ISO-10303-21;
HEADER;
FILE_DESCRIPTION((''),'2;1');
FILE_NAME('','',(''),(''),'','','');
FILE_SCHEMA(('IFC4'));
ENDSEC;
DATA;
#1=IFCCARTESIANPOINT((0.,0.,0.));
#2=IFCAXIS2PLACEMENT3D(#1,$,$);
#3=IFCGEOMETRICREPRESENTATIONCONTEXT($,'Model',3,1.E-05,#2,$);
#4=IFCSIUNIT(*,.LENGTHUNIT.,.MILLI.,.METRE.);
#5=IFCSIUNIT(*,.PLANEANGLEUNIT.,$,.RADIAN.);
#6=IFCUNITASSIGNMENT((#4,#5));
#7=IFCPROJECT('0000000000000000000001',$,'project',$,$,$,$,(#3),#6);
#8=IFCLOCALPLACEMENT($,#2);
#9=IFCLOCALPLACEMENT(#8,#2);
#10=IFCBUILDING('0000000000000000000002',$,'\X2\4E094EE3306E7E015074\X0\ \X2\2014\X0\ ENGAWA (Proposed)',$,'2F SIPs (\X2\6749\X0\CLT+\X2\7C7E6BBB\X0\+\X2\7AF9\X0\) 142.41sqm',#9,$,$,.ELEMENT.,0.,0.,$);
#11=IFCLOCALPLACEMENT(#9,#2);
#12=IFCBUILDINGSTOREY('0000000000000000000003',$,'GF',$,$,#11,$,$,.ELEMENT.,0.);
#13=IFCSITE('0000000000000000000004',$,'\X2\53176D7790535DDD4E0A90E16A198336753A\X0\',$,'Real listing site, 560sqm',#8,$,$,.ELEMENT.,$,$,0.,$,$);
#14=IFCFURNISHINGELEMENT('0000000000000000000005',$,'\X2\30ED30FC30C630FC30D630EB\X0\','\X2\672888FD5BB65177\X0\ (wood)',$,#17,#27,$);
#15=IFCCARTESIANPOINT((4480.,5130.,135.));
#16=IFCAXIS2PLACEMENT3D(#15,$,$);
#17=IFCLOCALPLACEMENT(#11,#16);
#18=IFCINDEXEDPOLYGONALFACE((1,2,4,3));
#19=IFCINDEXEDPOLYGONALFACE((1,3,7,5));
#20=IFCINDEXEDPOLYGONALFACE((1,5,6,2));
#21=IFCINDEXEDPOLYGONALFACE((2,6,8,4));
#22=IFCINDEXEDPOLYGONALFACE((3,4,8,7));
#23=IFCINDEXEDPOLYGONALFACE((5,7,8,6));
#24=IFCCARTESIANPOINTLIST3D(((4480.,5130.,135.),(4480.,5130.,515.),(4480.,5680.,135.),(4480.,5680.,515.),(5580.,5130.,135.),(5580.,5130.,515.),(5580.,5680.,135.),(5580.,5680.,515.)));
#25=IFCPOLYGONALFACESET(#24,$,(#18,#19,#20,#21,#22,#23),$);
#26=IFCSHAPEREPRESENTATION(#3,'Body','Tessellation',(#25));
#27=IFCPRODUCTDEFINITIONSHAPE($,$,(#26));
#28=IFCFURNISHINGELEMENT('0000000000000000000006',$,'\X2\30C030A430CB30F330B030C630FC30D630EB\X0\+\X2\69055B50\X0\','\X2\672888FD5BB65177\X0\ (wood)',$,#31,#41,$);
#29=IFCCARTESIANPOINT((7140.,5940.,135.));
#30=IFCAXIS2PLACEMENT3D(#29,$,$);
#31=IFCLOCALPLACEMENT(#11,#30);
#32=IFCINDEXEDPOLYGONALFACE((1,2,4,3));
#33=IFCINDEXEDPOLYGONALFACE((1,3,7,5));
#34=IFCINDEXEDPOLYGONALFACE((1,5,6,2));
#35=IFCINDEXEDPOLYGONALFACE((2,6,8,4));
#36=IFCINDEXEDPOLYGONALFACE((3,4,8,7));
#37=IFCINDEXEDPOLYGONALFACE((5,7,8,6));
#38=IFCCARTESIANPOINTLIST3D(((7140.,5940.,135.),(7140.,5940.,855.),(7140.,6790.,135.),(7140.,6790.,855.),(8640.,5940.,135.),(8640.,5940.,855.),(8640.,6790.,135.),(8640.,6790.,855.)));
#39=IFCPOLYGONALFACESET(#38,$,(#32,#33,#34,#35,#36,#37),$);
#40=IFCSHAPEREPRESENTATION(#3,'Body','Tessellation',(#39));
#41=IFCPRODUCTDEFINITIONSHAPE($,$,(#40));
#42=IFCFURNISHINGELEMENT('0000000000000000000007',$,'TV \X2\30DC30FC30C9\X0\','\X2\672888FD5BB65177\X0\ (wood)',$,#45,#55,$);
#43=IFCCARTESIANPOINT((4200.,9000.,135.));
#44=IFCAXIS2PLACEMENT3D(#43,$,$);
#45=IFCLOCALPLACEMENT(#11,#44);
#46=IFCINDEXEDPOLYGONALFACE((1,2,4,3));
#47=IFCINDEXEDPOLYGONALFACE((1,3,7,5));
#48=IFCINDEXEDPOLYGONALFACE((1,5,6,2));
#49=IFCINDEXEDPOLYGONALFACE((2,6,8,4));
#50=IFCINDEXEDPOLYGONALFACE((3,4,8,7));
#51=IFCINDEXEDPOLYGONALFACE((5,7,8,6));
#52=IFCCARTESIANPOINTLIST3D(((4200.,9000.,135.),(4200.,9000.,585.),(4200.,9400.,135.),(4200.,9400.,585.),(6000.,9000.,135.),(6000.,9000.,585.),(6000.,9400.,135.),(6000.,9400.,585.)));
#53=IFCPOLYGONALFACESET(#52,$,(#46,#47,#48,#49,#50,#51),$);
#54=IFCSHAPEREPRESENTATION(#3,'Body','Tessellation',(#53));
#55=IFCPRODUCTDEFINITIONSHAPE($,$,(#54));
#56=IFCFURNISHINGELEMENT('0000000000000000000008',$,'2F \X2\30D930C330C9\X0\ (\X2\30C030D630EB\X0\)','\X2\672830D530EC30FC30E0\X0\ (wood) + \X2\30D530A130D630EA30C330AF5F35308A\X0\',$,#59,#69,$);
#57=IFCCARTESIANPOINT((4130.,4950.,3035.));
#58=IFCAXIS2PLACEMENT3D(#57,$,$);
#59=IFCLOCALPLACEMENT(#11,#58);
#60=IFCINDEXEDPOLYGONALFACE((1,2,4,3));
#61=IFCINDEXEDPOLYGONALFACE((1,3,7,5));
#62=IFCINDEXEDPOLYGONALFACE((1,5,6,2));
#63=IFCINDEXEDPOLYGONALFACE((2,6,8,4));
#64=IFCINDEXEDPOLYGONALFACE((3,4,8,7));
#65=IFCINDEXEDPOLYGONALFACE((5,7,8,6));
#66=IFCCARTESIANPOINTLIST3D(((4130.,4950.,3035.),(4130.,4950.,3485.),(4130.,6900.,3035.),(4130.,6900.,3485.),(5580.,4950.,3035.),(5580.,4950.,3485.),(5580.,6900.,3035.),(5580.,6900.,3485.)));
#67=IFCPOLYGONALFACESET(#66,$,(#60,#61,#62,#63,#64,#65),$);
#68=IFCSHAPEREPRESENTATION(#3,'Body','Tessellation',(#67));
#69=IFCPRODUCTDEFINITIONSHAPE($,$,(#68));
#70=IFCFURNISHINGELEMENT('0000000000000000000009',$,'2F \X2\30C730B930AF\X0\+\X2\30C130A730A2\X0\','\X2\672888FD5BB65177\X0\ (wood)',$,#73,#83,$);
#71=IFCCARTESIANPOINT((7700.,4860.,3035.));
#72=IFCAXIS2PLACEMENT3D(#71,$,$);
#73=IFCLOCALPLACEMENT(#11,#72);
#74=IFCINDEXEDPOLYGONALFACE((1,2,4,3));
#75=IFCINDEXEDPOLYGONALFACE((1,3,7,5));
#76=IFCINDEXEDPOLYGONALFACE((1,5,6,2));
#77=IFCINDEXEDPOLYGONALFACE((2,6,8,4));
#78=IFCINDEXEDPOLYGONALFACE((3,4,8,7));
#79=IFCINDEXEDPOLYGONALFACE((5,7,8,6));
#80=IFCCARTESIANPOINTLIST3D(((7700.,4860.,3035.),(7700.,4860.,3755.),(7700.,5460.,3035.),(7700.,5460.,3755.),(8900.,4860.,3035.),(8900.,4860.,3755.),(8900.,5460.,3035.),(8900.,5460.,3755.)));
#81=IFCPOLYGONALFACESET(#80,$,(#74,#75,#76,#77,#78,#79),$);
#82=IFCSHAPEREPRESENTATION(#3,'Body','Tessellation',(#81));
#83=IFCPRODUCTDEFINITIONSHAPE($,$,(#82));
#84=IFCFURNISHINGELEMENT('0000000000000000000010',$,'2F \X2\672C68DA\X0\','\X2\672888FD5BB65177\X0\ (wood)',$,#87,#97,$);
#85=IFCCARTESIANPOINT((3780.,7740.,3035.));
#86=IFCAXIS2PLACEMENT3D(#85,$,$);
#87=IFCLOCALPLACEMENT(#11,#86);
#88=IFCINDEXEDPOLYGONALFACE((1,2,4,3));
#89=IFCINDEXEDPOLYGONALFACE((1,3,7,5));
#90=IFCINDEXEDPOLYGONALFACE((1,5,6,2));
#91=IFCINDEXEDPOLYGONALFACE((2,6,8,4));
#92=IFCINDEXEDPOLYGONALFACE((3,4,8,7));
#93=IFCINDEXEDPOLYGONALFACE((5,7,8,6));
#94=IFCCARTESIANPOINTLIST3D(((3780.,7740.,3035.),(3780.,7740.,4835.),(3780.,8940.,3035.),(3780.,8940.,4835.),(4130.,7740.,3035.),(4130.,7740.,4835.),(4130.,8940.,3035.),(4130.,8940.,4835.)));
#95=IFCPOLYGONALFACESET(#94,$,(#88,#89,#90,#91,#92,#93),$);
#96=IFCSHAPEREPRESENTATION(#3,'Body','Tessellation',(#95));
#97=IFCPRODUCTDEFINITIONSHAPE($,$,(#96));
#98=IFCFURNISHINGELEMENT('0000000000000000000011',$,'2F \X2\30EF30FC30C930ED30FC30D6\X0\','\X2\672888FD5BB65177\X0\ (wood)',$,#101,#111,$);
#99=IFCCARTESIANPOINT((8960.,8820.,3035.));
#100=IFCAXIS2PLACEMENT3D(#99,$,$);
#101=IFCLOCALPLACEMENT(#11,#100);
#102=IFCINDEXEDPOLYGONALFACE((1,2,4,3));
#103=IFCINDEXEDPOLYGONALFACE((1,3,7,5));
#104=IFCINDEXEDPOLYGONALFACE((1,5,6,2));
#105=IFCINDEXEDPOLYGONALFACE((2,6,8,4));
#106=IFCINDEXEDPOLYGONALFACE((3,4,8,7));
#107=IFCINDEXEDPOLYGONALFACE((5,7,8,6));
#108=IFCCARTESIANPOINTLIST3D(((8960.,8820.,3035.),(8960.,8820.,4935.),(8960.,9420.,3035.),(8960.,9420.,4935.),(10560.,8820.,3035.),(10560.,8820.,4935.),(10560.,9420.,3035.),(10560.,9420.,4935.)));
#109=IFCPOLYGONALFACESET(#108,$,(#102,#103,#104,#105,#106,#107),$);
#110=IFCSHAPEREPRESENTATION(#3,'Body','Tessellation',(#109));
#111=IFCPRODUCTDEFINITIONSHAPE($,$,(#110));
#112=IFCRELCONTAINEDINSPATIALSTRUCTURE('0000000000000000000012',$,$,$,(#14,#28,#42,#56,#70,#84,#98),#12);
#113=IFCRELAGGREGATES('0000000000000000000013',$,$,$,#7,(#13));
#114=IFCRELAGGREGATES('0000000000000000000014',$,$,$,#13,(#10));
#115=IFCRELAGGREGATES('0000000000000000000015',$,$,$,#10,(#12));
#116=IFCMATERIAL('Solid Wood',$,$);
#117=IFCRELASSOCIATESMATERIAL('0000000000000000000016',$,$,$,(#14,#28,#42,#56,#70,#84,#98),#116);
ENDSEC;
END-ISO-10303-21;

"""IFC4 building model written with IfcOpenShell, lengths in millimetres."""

from ifc_helpers import new_model, si_unit, frame, frame_2d, origin, place, context, project, spatial, rectangle, extrude, material, element, save


model = new_model("IFC4")

# Units and contexts
model_context = context("Model", 3, precision=1e-05, world=origin())
ifc_project = project(units=[si_unit("LENGTHUNIT", "METRE", prefix="MILLI"), si_unit("PLANEANGLEUNIT", "RADIAN")], contexts=[model_context])

# Site, building, storey
site_placement = place(None, origin())
site = spatial("IfcSite", under=ifc_project, at=site_placement, Name="北海道川上郡標茶町", ObjectType="Real listing site, 560sqm", CompositionType="ELEMENT", RefElevation=0.0)
building_placement = place(site_placement, origin())
building = spatial("IfcBuilding", under=site, at=building_placement, Name="三代の縁側 — ENGAWA (Proposed)", ObjectType="2F SIPs (杉CLT+籾殻+竹) 142.41sqm", CompositionType="ELEMENT", ElevationOfRefHeight=0.0, ElevationOfTerrain=0.0)
storey_placement = place(building_placement, origin())
storey = spatial("IfcBuildingStorey", under=building, at=storey_placement, Name="GF", CompositionType="ELEMENT", Elevation=0.0)

# Shared definitions
ifc_material_1 = material(Name="Solid Wood")

# Furnishing elements
furnishing_1_placement = place(storey_placement, frame((4480.0, 5130.0, 135.0)))
element("IfcFurnishingElement", 1, at=furnishing_1_placement, inside=storey, material=ifc_material_1, Name="ローテーブル", Description="木製家具 (wood)", context=model_context, shape_type="SweptSolid", body=[
    extrude(rectangle(XDim=1100.0, YDim=550.0, at=frame_2d((550.0, 275.0))), frame((4480.0, 5130.0, 135.0)), (0.0, 0.0, 1.0), 380.0),
])
furnishing_2_placement = place(storey_placement, frame((7140.0, 5940.0, 135.0)))
element("IfcFurnishingElement", 2, at=furnishing_2_placement, inside=storey, material=ifc_material_1, Name="ダイニングテーブル+椅子", Description="木製家具 (wood)", context=model_context, shape_type="SweptSolid", body=[
    extrude(rectangle(XDim=1500.0, YDim=850.0, at=frame_2d((750.0, 425.0))), frame((7140.0, 5940.0, 135.0)), (0.0, 0.0, 1.0), 720.0),
])
furnishing_3_placement = place(storey_placement, frame((4200.0, 9000.0, 135.0)))
element("IfcFurnishingElement", 3, at=furnishing_3_placement, inside=storey, material=ifc_material_1, Name="TV ボード", Description="木製家具 (wood)", context=model_context, shape_type="SweptSolid", body=[
    extrude(rectangle(XDim=1800.0, YDim=400.0, at=frame_2d((900.0, 200.0))), frame((4200.0, 9000.0, 135.0)), (0.0, 0.0, 1.0), 450.0),
])
furnishing_4_placement = place(storey_placement, frame((4130.0, 4950.0, 3035.0)))
element("IfcFurnishingElement", 4, at=furnishing_4_placement, inside=storey, material=ifc_material_1, Name="2F ベッド (ダブル)", Description="木フレーム (wood) + ファブリック張り", context=model_context, shape_type="SweptSolid", body=[
    extrude(rectangle(XDim=1450.0, YDim=1950.0, at=frame_2d((725.0, 975.0))), frame((4130.0, 4950.0, 3035.0)), (0.0, 0.0, 1.0), 450.0),
])
furnishing_5_placement = place(storey_placement, frame((7700.0, 4860.0, 3035.0)))
element("IfcFurnishingElement", 5, at=furnishing_5_placement, inside=storey, material=ifc_material_1, Name="2F デスク+チェア", Description="木製家具 (wood)", context=model_context, shape_type="SweptSolid", body=[
    extrude(rectangle(XDim=1200.0, YDim=600.0, at=frame_2d((600.0, 300.0))), frame((7700.0, 4860.0, 3035.0)), (0.0, 0.0, 1.0), 720.0),
])
furnishing_6_placement = place(storey_placement, frame((3780.0, 7740.0, 3035.0)))
element("IfcFurnishingElement", 6, at=furnishing_6_placement, inside=storey, material=ifc_material_1, Name="2F 本棚", Description="木製家具 (wood)", context=model_context, shape_type="SweptSolid", body=[
    extrude(rectangle(XDim=350.0, YDim=1200.0, at=frame_2d((175.0, 600.0))), frame((3780.0, 7740.0, 3035.0)), (0.0, 0.0, 1.0), 1800.0),
])
furnishing_7_placement = place(storey_placement, frame((8960.0, 8820.0, 3035.0)))
element("IfcFurnishingElement", 7, at=furnishing_7_placement, inside=storey, material=ifc_material_1, Name="2F ワードローブ", Description="木製家具 (wood)", context=model_context, shape_type="SweptSolid", body=[
    extrude(rectangle(XDim=1600.0, YDim=600.0, at=frame_2d((800.0, 300.0))), frame((8960.0, 8820.0, 3035.0)), (0.0, 0.0, 1.0), 1900.0),
])

save(model, "model.ifc")
